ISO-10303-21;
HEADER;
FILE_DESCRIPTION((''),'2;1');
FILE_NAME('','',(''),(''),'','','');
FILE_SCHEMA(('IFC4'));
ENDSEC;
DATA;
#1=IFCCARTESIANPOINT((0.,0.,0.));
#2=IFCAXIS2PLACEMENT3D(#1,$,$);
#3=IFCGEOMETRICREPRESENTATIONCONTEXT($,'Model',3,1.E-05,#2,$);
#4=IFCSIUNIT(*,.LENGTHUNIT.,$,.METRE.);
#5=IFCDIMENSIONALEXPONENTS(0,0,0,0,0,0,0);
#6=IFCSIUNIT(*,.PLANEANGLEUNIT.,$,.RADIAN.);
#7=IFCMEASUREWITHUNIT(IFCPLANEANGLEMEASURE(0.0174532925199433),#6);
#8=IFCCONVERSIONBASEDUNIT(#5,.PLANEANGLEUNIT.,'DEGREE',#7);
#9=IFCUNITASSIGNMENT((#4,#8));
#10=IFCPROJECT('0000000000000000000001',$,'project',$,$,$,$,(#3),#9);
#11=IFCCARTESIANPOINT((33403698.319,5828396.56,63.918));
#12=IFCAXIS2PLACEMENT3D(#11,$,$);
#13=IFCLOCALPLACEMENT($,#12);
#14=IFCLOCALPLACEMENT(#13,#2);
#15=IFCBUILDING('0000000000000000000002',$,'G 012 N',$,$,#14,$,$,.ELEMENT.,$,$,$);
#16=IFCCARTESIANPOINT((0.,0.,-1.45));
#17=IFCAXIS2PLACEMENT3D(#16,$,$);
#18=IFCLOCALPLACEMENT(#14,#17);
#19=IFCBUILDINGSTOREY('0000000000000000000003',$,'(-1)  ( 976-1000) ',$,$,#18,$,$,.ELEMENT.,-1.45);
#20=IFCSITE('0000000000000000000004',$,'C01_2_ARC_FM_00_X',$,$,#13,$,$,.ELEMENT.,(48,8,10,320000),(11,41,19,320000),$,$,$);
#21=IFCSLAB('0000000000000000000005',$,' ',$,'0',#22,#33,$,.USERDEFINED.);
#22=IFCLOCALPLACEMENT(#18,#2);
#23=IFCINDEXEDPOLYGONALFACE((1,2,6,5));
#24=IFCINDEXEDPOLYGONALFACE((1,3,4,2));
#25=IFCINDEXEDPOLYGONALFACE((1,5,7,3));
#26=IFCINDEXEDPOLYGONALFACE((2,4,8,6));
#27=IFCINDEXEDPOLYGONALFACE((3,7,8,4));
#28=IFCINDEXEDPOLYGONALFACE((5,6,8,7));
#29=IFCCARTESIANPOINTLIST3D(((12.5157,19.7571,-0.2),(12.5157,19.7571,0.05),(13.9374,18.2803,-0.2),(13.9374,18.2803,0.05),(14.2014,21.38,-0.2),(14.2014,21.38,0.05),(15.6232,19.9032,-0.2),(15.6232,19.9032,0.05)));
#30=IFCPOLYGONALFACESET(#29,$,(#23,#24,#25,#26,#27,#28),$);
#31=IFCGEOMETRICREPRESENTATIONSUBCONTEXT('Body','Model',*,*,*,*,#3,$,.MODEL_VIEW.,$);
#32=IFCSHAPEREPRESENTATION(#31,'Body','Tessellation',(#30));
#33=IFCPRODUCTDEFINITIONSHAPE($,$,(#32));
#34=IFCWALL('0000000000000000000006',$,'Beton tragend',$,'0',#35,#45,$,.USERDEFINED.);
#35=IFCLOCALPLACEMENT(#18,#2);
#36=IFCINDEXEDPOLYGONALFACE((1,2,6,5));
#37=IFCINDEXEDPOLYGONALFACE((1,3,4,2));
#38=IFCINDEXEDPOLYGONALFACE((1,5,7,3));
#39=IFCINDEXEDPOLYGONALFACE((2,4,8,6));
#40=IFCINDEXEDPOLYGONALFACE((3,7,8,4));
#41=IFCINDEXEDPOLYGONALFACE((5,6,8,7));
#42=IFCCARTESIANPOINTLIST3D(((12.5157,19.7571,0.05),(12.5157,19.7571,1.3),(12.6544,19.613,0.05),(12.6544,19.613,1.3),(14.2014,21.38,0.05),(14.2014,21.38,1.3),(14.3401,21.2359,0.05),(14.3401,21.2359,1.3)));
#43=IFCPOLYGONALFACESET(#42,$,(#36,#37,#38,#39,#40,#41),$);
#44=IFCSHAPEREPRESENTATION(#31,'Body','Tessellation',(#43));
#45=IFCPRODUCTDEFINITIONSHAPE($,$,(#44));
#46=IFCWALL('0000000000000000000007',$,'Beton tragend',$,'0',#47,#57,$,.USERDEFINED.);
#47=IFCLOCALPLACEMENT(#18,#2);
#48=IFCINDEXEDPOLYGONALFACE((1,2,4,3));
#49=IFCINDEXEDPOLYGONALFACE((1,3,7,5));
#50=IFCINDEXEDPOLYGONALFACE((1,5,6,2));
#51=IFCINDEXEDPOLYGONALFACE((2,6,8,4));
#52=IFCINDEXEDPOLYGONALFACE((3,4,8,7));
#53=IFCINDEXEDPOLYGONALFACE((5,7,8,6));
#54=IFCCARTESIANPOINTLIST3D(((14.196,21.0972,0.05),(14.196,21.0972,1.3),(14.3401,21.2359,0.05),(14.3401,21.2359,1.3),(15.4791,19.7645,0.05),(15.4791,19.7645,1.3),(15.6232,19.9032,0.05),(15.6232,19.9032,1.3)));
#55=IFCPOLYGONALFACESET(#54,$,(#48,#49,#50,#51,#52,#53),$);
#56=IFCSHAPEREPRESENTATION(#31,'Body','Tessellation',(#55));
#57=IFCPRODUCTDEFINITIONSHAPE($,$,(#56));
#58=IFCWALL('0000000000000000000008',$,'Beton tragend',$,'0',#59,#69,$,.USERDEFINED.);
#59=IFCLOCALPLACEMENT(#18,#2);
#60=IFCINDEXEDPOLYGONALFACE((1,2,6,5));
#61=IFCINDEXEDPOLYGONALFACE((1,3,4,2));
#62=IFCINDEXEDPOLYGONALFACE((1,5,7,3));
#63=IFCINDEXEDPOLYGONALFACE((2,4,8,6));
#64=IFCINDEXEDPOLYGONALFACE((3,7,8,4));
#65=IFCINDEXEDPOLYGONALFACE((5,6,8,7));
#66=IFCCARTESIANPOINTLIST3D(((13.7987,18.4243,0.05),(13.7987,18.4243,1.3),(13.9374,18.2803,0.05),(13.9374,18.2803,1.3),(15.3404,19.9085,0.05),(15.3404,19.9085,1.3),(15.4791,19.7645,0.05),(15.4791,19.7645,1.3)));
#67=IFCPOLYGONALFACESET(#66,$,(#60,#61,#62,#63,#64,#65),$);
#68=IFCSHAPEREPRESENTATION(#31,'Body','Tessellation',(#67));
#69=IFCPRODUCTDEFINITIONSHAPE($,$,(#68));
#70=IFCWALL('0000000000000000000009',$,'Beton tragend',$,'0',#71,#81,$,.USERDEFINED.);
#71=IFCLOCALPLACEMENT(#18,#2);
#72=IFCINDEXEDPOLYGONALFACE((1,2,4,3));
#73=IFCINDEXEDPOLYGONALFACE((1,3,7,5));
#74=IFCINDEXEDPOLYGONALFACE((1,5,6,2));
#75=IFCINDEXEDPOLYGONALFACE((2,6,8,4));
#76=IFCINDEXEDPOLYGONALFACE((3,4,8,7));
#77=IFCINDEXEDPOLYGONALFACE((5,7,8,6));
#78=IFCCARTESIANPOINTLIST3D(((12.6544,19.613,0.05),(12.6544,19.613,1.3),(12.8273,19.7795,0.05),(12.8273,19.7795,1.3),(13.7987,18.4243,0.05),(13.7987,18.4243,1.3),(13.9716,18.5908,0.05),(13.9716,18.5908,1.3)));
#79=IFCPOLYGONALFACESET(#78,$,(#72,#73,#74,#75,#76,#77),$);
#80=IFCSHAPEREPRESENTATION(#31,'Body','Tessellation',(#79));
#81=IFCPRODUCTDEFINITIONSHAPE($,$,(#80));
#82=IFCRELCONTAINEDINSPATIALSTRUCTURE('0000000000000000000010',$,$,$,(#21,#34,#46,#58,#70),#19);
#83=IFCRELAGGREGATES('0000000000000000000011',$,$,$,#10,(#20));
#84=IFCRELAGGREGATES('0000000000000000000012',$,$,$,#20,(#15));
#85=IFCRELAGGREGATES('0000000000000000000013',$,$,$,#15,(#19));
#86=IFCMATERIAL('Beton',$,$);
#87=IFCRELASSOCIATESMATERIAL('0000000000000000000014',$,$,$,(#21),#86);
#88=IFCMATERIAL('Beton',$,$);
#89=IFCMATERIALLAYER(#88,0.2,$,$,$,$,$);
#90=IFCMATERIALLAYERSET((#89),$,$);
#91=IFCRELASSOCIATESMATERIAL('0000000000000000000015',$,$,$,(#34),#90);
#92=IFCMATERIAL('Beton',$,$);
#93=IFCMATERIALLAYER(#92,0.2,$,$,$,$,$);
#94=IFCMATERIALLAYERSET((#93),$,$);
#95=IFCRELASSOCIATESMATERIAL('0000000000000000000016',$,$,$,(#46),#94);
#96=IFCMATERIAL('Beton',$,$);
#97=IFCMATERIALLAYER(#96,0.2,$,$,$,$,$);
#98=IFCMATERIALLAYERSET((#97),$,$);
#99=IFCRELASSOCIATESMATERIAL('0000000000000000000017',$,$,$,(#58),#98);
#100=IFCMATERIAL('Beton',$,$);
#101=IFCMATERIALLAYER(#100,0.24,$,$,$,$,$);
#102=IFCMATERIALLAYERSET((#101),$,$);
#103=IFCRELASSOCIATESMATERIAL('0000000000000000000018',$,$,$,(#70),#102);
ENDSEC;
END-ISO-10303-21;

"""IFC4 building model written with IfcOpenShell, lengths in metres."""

from ifc_helpers import new_model, entity, si_unit, converted_unit, frame, frame_2d, origin, origin_with_axes, place, context, subcontext, project, spatial, rectangle, extrude, material, layer, layer_set, layer_usage, element, save


model = new_model("IFC4")

# Units and contexts
model_context = context("Model", 3, precision=1e-05, world=origin())
body_context = subcontext(model_context, "Body", "Model", "MODEL_VIEW")
ifc_project = project(units=[si_unit("LENGTHUNIT", "METRE"), converted_unit("PLANEANGLEUNIT", "DEGREE", entity("IfcPlaneAngleMeasure", 0.0174532925199433), si_unit("PLANEANGLEUNIT", "RADIAN"), dimensions=[0, 0, 0, 0, 0, 0, 0])], contexts=[model_context])

# Site, building, storey
site_placement = place(None, frame((33403698.319, 5828396.56, 63.918)))
site = spatial("IfcSite", under=ifc_project, at=site_placement, Name="C01_2_ARC_FM_00_X", CompositionType="ELEMENT", RefLatitude=(48, 8, 10, 320000), RefLongitude=(11, 41, 19, 320000))
building_placement = place(site_placement, origin())
building = spatial("IfcBuilding", under=site, at=building_placement, Name="G 012 N", CompositionType="ELEMENT")
storey_placement = place(building_placement, frame((0.0, 0.0, -1.45)))
storey = spatial("IfcBuildingStorey", under=building, at=storey_placement, Name="(-1)  ( 976-1000) ", CompositionType="ELEMENT", Elevation=-1.45)

# Slab
ifc_material_1 = material(Name="Beton")
slab_placement = place(storey_placement, frame((12.5157, 18.2803, -0.2)))
element("IfcSlab", 1, at=slab_placement, inside=storey, material=ifc_material_1, Name=" ", ObjectType="0", PredefinedType="USERDEFINED", context=body_context, shape_type="SweptSolid", body=[
    extrude(rectangle(XDim=2.34, YDim=2.05, at=frame_2d((-0.132, -1.5499), x_axis=(-0.720408, -0.693551))), frame((1.6858, 3.0997, 0.0), z_axis=(0.0, 0.0, 1.0), x_axis=(1.0, 0.0, 0.0)), (0.0, 0.0, 1.0), 0.25),
])

# Walls
ifc_material_2 = material(Name="Beton")
ifc_layer_1 = layer(ifc_material_2, 0.2)
ifc_layer_set_1 = layer_set([ifc_layer_1])
ifc_layer_usage_1 = layer_usage(ifc_layer_set_1, "AXIS2", "POSITIVE", 0.0)
wall_1_placement = place(storey_placement, frame((14.2014, 21.38, 0.05), z_axis=(0.0, 0.0, 1.0), x_axis=(-0.720408, -0.693551, 0.0)))
element("IfcWall", 2, at=wall_1_placement, inside=storey, material=ifc_layer_usage_1, Name="Beton tragend", ObjectType="0", PredefinedType="USERDEFINED", context=body_context, shape_type="SweptSolid", body=[
    extrude(rectangle(XDim=2.34, YDim=0.2, at=frame_2d((1.17, 0.1), x_axis=(1.0, 0.0))), origin_with_axes(), (0.0, 0.0, 1.0), 1.25),
])
ifc_material_3 = material(Name="Beton")
ifc_layer_2 = layer(ifc_material_3, 0.2)
ifc_layer_set_2 = layer_set([ifc_layer_2])
ifc_layer_usage_2 = layer_usage(ifc_layer_set_2, "AXIS2", "POSITIVE", 0.0)
wall_2_placement = place(storey_placement, frame((15.6232, 19.9032, 0.05), z_axis=(0.0, 0.0, 1.0), x_axis=(-0.693551, 0.720408, 0.0)))
element("IfcWall", 3, at=wall_2_placement, inside=storey, material=ifc_layer_usage_2, Name="Beton tragend", ObjectType="0", PredefinedType="USERDEFINED", context=body_context, shape_type="SweptSolid", body=[
    extrude(rectangle(XDim=1.85, YDim=0.2, at=frame_2d((0.925, 0.1), x_axis=(1.0, 0.0))), origin_with_axes(), (0.0, 0.0, 1.0), 1.25),
])
ifc_material_4 = material(Name="Beton")
ifc_layer_3 = layer(ifc_material_4, 0.2)
ifc_layer_set_3 = layer_set([ifc_layer_3])
ifc_layer_usage_3 = layer_usage(ifc_layer_set_3, "AXIS2", "POSITIVE", 0.0)
wall_3_placement = place(storey_placement, frame((13.9374, 18.2803, 0.05), z_axis=(0.0, 0.0, 1.0), x_axis=(0.720408, 0.693551, 0.0)))
element("IfcWall", 4, at=wall_3_placement, inside=storey, material=ifc_layer_usage_3, Name="Beton tragend", ObjectType="0", PredefinedType="USERDEFINED", context=body_context, shape_type="SweptSolid", body=[
    extrude(rectangle(XDim=2.14, YDim=0.2, at=frame_2d((1.07, 0.1), x_axis=(1.0, 0.0))), origin_with_axes(), (0.0, 0.0, 1.0), 1.25),
])
ifc_material_5 = material(Name="Beton")
ifc_layer_4 = layer(ifc_material_5, 0.24)
ifc_layer_set_4 = layer_set([ifc_layer_4])
ifc_layer_usage_4 = layer_usage(ifc_layer_set_4, "AXIS2", "POSITIVE", 0.0)
wall_4_placement = place(storey_placement, frame((13.9716, 18.5908, 0.05), z_axis=(0.0, 0.0, 1.0), x_axis=(-0.693551, 0.720408, 0.0)))
element("IfcWall", 5, at=wall_4_placement, inside=storey, material=ifc_layer_usage_4, Name="Beton tragend", ObjectType="0", PredefinedType="USERDEFINED", context=body_context, shape_type="SweptSolid", body=[
    extrude(rectangle(XDim=1.65, YDim=0.24, at=frame_2d((0.825, 0.12), x_axis=(1.0, 0.0))), origin_with_axes(), (0.0, 0.0, 1.0), 1.25),
])

save(model, "model.ifc")
